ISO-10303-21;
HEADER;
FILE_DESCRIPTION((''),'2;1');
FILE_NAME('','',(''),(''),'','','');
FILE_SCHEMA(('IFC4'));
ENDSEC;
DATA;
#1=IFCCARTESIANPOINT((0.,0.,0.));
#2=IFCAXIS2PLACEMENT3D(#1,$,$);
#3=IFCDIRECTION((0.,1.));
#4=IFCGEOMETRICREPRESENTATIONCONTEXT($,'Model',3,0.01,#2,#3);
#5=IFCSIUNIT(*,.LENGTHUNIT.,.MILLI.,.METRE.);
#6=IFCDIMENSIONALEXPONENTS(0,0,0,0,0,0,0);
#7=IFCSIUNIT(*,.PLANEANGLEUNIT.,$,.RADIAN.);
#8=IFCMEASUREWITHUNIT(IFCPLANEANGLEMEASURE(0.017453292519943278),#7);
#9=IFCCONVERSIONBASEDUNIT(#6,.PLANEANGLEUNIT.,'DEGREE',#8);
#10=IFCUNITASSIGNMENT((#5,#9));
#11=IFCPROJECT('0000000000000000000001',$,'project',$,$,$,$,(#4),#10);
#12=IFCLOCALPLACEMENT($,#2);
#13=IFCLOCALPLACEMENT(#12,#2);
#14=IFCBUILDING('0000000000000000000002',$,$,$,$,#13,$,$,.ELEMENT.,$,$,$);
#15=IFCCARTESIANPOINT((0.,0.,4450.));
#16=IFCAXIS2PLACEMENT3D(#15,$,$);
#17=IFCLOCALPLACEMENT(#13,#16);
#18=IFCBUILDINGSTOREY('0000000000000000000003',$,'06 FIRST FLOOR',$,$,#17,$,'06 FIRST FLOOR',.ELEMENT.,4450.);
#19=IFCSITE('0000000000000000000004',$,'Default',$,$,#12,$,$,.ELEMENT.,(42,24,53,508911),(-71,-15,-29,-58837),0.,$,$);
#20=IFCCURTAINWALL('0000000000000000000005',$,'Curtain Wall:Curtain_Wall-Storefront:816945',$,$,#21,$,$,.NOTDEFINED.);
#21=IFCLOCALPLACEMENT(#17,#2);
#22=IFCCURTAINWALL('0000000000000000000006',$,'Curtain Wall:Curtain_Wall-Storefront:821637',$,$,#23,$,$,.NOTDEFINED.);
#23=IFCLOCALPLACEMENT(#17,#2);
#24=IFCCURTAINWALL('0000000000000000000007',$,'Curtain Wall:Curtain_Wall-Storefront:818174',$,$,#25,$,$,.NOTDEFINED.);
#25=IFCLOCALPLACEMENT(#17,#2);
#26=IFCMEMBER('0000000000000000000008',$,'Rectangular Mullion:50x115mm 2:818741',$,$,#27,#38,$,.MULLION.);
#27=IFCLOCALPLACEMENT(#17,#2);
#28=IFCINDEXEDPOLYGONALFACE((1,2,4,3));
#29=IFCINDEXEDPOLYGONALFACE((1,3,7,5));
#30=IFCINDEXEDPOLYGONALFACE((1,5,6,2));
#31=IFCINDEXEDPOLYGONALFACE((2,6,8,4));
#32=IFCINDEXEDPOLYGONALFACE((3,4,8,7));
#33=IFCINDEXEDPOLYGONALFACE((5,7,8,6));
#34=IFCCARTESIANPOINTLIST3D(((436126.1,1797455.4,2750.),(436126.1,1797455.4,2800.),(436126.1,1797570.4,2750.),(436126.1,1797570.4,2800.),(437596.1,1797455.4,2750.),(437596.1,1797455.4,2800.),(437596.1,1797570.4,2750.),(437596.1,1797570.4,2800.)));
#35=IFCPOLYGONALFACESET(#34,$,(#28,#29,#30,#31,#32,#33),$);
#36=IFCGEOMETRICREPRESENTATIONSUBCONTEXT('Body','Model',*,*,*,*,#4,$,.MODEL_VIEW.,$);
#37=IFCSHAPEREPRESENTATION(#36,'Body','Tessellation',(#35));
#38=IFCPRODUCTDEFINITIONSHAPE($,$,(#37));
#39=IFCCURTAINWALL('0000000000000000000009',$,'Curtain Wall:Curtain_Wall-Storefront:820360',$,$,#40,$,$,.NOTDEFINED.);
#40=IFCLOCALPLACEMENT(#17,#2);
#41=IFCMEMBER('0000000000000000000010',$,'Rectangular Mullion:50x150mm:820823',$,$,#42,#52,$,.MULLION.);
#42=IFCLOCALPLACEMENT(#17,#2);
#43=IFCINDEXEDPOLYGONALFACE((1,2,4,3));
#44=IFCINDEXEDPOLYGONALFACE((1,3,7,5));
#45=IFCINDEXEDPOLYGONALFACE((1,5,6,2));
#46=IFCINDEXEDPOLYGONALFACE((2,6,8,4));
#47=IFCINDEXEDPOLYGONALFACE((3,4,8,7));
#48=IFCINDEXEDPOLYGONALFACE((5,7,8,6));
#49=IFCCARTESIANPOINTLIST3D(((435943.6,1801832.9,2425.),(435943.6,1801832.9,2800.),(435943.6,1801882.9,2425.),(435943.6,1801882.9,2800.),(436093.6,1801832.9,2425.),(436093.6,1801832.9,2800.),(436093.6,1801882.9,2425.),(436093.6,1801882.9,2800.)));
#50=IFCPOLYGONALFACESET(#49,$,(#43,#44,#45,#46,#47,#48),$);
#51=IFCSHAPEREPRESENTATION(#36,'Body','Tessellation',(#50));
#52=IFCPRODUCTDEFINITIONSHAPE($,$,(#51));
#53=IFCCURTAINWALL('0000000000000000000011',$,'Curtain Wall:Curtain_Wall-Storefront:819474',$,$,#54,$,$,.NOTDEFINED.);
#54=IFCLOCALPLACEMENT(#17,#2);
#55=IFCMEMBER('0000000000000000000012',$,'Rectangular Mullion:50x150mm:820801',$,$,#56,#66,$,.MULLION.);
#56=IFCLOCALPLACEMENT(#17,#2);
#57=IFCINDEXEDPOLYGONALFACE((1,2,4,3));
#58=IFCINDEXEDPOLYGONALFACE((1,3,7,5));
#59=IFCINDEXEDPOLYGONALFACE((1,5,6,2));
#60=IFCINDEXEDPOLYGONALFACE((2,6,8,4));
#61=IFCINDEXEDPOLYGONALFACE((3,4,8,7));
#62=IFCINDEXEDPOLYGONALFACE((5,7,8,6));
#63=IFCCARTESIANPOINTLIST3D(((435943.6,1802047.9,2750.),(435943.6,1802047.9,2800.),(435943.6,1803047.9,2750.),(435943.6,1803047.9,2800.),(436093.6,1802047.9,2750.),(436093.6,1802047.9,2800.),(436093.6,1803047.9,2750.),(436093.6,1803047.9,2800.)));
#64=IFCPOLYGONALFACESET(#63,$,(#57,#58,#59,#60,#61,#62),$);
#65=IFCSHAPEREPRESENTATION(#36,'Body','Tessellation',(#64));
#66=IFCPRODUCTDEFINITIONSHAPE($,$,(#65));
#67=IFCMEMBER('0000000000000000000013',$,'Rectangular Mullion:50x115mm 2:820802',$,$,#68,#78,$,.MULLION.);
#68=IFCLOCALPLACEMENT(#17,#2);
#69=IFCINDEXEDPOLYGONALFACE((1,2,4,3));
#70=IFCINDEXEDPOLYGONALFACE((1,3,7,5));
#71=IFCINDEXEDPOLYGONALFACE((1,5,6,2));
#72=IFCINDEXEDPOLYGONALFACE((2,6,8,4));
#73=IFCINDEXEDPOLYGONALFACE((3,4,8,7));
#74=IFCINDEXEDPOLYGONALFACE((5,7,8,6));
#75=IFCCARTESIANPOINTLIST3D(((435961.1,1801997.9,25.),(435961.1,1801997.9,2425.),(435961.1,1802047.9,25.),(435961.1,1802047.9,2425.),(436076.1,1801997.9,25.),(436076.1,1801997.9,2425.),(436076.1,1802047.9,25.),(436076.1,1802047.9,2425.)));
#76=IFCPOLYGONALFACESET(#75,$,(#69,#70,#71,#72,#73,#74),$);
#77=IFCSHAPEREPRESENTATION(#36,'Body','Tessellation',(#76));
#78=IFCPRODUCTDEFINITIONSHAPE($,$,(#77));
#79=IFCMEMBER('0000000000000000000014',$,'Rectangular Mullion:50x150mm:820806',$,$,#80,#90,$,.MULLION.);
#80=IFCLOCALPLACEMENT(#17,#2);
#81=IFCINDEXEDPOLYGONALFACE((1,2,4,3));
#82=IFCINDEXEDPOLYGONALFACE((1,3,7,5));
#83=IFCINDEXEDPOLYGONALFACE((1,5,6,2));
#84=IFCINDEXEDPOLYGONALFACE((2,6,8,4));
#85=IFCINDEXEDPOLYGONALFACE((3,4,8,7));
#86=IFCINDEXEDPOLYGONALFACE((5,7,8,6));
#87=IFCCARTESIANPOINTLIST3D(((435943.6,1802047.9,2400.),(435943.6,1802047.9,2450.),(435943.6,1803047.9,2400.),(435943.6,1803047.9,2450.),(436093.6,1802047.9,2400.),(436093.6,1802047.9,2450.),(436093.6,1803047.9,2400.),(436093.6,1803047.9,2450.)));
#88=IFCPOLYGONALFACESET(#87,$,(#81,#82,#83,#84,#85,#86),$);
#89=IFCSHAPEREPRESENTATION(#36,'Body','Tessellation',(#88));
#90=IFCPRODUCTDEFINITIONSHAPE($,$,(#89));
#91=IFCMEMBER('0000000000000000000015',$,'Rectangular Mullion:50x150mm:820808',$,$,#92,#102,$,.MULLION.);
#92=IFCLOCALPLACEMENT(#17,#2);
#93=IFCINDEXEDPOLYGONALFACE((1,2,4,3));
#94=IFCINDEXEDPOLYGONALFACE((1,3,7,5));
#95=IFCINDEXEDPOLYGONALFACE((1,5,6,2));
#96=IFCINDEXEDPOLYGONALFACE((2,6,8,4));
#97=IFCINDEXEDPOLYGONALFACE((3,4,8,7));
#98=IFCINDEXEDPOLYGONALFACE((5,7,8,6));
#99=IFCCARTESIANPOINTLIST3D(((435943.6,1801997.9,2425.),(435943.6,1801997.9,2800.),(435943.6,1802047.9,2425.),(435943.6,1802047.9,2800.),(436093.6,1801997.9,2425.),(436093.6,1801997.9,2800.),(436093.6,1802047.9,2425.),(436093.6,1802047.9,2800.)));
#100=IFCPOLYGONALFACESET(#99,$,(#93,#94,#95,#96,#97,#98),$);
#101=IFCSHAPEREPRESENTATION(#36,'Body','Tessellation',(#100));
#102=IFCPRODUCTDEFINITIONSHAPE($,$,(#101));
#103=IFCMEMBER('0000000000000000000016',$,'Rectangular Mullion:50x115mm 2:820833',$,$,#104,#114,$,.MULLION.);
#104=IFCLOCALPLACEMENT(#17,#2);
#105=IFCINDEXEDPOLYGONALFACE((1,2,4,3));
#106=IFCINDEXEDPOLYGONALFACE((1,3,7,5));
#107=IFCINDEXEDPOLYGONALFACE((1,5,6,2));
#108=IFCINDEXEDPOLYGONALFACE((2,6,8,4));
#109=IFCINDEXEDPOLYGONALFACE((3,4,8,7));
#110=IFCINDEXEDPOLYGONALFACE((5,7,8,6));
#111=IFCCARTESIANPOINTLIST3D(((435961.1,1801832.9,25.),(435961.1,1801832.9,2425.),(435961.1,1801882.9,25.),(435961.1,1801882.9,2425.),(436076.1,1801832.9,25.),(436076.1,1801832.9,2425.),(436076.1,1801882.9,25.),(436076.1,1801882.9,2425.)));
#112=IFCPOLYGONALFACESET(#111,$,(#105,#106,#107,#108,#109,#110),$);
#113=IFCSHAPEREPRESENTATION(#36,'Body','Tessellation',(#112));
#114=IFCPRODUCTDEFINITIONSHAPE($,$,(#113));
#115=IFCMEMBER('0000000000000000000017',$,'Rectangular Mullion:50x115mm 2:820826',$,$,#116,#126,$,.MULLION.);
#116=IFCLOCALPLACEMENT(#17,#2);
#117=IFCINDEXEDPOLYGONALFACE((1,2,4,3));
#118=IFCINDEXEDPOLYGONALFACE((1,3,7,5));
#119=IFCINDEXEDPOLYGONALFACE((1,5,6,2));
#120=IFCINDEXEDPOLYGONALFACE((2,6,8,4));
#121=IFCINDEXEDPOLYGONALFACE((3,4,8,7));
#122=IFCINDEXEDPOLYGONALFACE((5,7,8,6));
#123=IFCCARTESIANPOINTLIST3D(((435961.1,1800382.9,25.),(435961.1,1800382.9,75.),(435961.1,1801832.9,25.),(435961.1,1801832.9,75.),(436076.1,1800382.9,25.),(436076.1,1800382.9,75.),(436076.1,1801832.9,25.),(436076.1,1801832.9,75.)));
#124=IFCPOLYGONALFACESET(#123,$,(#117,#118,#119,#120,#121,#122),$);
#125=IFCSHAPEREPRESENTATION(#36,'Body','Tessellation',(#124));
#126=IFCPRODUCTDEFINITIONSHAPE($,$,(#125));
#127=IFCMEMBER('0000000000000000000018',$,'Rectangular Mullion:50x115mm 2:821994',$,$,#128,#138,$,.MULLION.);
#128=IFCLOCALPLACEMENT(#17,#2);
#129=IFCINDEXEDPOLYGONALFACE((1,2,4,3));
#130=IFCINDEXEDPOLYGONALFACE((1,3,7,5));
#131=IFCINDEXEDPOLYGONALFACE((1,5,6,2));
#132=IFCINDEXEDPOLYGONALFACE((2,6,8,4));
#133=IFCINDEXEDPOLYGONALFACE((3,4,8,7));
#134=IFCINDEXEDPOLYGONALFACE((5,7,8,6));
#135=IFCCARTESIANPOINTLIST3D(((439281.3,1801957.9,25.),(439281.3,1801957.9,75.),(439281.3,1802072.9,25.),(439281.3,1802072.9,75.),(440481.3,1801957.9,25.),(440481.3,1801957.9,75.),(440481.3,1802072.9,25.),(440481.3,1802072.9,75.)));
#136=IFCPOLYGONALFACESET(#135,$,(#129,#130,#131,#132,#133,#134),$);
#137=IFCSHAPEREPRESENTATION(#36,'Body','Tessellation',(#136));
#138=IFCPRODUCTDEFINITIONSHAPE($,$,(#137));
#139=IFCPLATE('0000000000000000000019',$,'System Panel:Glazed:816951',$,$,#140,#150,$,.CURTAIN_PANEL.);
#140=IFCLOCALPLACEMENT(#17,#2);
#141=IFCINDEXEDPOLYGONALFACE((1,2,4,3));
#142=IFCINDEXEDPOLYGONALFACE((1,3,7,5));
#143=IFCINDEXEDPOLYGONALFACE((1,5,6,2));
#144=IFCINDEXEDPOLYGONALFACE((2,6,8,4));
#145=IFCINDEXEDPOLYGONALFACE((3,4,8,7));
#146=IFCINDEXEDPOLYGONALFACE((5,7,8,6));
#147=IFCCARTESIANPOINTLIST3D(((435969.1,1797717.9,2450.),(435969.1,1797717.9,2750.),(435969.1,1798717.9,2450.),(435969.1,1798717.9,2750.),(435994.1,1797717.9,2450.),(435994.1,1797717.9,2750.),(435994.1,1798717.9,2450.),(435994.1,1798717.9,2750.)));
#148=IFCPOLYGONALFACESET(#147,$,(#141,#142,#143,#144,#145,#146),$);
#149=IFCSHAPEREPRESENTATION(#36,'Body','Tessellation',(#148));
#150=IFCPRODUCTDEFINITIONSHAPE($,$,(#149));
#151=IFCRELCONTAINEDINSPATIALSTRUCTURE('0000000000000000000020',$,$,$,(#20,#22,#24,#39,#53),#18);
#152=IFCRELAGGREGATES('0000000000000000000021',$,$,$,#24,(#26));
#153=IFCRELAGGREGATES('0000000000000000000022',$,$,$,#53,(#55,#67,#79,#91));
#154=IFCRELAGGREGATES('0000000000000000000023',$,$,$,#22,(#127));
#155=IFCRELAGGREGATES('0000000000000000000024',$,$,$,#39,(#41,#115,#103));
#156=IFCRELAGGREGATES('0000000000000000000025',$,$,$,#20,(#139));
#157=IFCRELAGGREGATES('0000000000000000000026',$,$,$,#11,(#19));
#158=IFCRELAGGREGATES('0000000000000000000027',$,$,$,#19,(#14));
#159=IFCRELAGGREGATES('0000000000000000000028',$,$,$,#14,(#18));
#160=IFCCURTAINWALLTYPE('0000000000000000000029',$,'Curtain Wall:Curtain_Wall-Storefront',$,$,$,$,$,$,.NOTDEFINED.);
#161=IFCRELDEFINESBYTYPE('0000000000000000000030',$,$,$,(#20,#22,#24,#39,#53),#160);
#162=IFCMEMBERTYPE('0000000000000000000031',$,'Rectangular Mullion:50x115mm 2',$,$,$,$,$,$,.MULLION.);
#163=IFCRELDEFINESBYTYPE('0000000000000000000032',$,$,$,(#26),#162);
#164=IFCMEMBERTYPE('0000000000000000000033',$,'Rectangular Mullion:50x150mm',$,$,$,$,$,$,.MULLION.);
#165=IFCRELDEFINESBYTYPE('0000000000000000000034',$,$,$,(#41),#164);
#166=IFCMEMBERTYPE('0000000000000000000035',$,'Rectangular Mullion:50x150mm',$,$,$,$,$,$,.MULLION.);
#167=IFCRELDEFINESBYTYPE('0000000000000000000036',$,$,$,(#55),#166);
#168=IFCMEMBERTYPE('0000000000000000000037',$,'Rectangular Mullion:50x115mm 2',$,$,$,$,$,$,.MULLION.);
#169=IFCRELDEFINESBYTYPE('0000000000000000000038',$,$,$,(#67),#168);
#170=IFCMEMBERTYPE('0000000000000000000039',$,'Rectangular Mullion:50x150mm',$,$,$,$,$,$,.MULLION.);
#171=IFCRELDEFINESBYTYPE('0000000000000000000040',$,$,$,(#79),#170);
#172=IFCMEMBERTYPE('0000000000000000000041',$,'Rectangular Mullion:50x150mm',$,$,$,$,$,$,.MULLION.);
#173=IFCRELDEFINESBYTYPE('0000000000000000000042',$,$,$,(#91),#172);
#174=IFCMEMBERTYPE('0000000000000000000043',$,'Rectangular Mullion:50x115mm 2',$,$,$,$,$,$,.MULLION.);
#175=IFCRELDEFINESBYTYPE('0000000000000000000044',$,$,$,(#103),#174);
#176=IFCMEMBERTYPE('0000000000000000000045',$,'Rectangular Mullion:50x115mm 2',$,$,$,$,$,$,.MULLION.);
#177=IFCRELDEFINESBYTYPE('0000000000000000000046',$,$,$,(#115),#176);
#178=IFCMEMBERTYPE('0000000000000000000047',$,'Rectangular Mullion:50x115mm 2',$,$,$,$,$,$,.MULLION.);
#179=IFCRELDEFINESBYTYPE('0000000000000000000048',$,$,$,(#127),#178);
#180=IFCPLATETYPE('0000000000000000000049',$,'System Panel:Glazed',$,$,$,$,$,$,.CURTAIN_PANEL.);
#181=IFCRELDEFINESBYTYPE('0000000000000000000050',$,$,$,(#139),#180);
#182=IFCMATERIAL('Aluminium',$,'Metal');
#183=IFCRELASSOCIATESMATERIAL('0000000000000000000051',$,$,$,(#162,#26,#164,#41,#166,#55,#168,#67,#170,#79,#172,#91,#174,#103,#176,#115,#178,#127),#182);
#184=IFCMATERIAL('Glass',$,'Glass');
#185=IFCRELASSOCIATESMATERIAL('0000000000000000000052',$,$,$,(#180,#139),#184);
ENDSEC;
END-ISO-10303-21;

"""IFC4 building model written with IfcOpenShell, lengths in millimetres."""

from ifc_helpers import new_model, entity, si_unit, converted_unit, direction, frame, origin, place, context, subcontext, project, spatial, indexed_curve, outline, extrude, source, transform, mapped, material, type_object, type_shapes, element, aggregate, save


model = new_model("IFC4")

# Units and contexts
model_context = context("Model", 3, precision=0.01, world=origin(), true_north=direction((0.0, 1.0)))
body_context = subcontext(model_context, "Body", "Model", "MODEL_VIEW")
ifc_project = project(units=[si_unit("LENGTHUNIT", "METRE", prefix="MILLI"), converted_unit("PLANEANGLEUNIT", "DEGREE", entity("IfcPlaneAngleMeasure", 0.017453292519943278), si_unit("PLANEANGLEUNIT", "RADIAN"), dimensions=[0, 0, 0, 0, 0, 0, 0])], contexts=[model_context])

# Site, building, storey
site_placement = place(None, origin())
site = spatial("IfcSite", under=ifc_project, at=site_placement, Name="Default", CompositionType="ELEMENT", RefLatitude=(42, 24, 53, 508911), RefLongitude=(-71, -15, -29, -58837), RefElevation=0.0)
building_placement = place(site_placement, origin())
building = spatial("IfcBuilding", under=site, at=building_placement, CompositionType="ELEMENT")
storey_placement = place(building_placement, frame((0.0, 0.0, 4450.0)))
storey = spatial("IfcBuildingStorey", under=building, at=storey_placement, Name="06 FIRST FLOOR", LongName="06 FIRST FLOOR", CompositionType="ELEMENT", Elevation=4450.0)

# Curtain walls, member
curtain_wall_type = type_object("IfcCurtainWallType", Name="Curtain Wall:Curtain_Wall-Storefront", PredefinedType="NOTDEFINED")
curtain_wall_1_placement = place(storey_placement, frame((0.0, 0.0, -4450.0)))
curtain_wall_1 = element("IfcCurtainWall", 1, at=curtain_wall_1_placement, inside=storey, type_object=curtain_wall_type, Name="Curtain Wall:Curtain_Wall-Storefront:816945", PredefinedType="NOTDEFINED")
ifc_material_1 = material(Name="Aluminium", Category="Metal")
curtain_wall_2_placement = place(storey_placement, frame((0.0, 0.0, -4450.0)))
curtain_wall_2 = element("IfcCurtainWall", 2, at=curtain_wall_2_placement, inside=storey, type_object=curtain_wall_type, Name="Curtain Wall:Curtain_Wall-Storefront:821637", PredefinedType="NOTDEFINED")
curtain_wall_3_placement = place(storey_placement, frame((0.0, 0.0, -4450.0)))
curtain_wall_3 = element("IfcCurtainWall", 3, at=curtain_wall_3_placement, inside=storey, type_object=curtain_wall_type, Name="Curtain Wall:Curtain_Wall-Storefront:818174", PredefinedType="NOTDEFINED")
member_type_1 = type_object("IfcMemberType", Name="Rectangular Mullion:50x115mm 2", PredefinedType="MULLION", material=ifc_material_1)
shared_shape_1 = source(origin(), body_context, "Body", "SweptSolid", [
    extrude(outline(indexed_curve([(-25.0, -57.5), (25.0, -57.5), (25.0, 57.5), (-25.0, 57.5), (-25.0, -57.5)], self_intersect=False)), frame((-25.0, 0.0, -1470.0), z_axis=(0.0, 0.0, 1.0), x_axis=(-1.0, 0.0, 0.0)), (0.0, 0.0, 1.0), 1470.0),
])
type_shapes(member_type_1, [shared_shape_1])
member_1_placement = place(curtain_wall_3_placement, frame((437596.1, 1797512.9, 7250.0), z_axis=(1.0, 0.0, 0.0), x_axis=(0.0, 0.0, 1.0)))
member_1 = element("IfcMember", 4, at=member_1_placement, type_object=member_type_1, material=ifc_material_1, Name="Rectangular Mullion:50x115mm 2:818741", PredefinedType="MULLION", context=body_context, shape_type="MappedRepresentation", body=[
    mapped(shared_shape_1, transform((0.0, 0.0, 0.0), scale=1.0)),
])
aggregate(curtain_wall_3, [member_1])

# Curtain wall, member
curtain_wall_4_placement = place(storey_placement, frame((0.0, 0.0, -4450.0)))
curtain_wall_4 = element("IfcCurtainWall", 5, at=curtain_wall_4_placement, inside=storey, type_object=curtain_wall_type, Name="Curtain Wall:Curtain_Wall-Storefront:820360", PredefinedType="NOTDEFINED")
member_type_2 = type_object("IfcMemberType", Name="Rectangular Mullion:50x150mm", PredefinedType="MULLION", material=ifc_material_1)
shared_shape_2 = source(origin(), body_context, "Body", "SweptSolid", [
    extrude(outline(indexed_curve([(-25.0, -75.0), (25.0, -75.0), (25.0, 75.0), (-25.0, 75.0), (-25.0, -75.0)], self_intersect=False)), frame((-25.0, 0.0, -375.0), z_axis=(0.0, 0.0, 1.0), x_axis=(-1.0, 0.0, 0.0)), (0.0, 0.0, 1.0), 375.0),
])
type_shapes(member_type_2, [shared_shape_2])
member_2_placement = place(curtain_wall_4_placement, frame((436018.6, 1801882.9, 7250.0), z_axis=(0.0, 0.0, 1.0), x_axis=(0.0, 1.0, 0.0)))
member_2 = element("IfcMember", 6, at=member_2_placement, type_object=member_type_2, material=ifc_material_1, Name="Rectangular Mullion:50x150mm:820823", PredefinedType="MULLION", context=body_context, shape_type="MappedRepresentation", body=[
    mapped(shared_shape_2, transform((0.0, 0.0, 0.0), scale=1.0)),
])

# Curtain wall, members
curtain_wall_5_placement = place(storey_placement, frame((0.0, 0.0, -4450.0)))
curtain_wall_5 = element("IfcCurtainWall", 7, at=curtain_wall_5_placement, inside=storey, type_object=curtain_wall_type, Name="Curtain Wall:Curtain_Wall-Storefront:819474", PredefinedType="NOTDEFINED")
member_type_3 = type_object("IfcMemberType", Name="Rectangular Mullion:50x150mm", PredefinedType="MULLION", material=ifc_material_1)
shared_shape_3 = source(origin(), body_context, "Body", "SweptSolid", [
    extrude(outline(indexed_curve([(-25.0, -75.0), (25.0, -75.0), (25.0, 75.0), (-25.0, 75.0), (-25.0, -75.0)], self_intersect=False)), frame((-25.0, 0.0, -1000.0), z_axis=(0.0, 0.0, 1.0), x_axis=(-1.0, 0.0, 0.0)), (0.0, 0.0, 1.0), 1000.0),
])
type_shapes(member_type_3, [shared_shape_3])
member_3_placement = place(curtain_wall_5_placement, frame((436018.6, 1802047.9, 7250.0), z_axis=(0.0, -1.0, 0.0), x_axis=(0.0, 0.0, 1.0)))
member_3 = element("IfcMember", 8, at=member_3_placement, type_object=member_type_3, material=ifc_material_1, Name="Rectangular Mullion:50x150mm:820801", PredefinedType="MULLION", context=body_context, shape_type="MappedRepresentation", body=[
    mapped(shared_shape_3, transform((0.0, 0.0, 0.0), scale=1.0)),
])
member_type_4 = type_object("IfcMemberType", Name="Rectangular Mullion:50x115mm 2", PredefinedType="MULLION", material=ifc_material_1)
shared_shape_4 = source(origin(), body_context, "Body", "SweptSolid", [
    extrude(outline(indexed_curve([(-25.0, -57.5), (25.0, -57.5), (25.0, 57.5), (-25.0, 57.5), (-25.0, -57.5)], self_intersect=False)), frame((-25.0, 0.0, -2400.0), z_axis=(0.0, 0.0, 1.0), x_axis=(-1.0, 0.0, 0.0)), (0.0, 0.0, 1.0), 2400.0),
])
type_shapes(member_type_4, [shared_shape_4])
member_4_placement = place(curtain_wall_5_placement, frame((436018.6, 1801997.9, 4475.0), z_axis=(0.0, 0.0, -1.0), x_axis=(0.0, -1.0, 0.0)))
member_4 = element("IfcMember", 9, at=member_4_placement, type_object=member_type_4, material=ifc_material_1, Name="Rectangular Mullion:50x115mm 2:820802", PredefinedType="MULLION", context=body_context, shape_type="MappedRepresentation", body=[
    mapped(shared_shape_4, transform((0.0, 0.0, 0.0), scale=1.0)),
])
member_type_5 = type_object("IfcMemberType", Name="Rectangular Mullion:50x150mm", PredefinedType="MULLION", material=ifc_material_1)
shared_shape_5 = source(origin(), body_context, "Body", "SweptSolid", [
    extrude(outline(indexed_curve([(-25.0, -75.0), (25.0, -75.0), (25.0, 75.0), (-25.0, 75.0), (-25.0, -75.0)], self_intersect=False)), frame((0.0, 0.0, -1000.0), z_axis=(0.0, 0.0, 1.0), x_axis=(-1.0, 0.0, 0.0)), (0.0, 0.0, 1.0), 1000.0),
])
type_shapes(member_type_5, [shared_shape_5])
member_5_placement = place(curtain_wall_5_placement, frame((436018.6, 1802047.9, 6875.0), z_axis=(0.0, -1.0, 0.0), x_axis=(0.0, 0.0, 1.0)))
member_5 = element("IfcMember", 10, at=member_5_placement, type_object=member_type_5, material=ifc_material_1, Name="Rectangular Mullion:50x150mm:820806", PredefinedType="MULLION", context=body_context, shape_type="MappedRepresentation", body=[
    mapped(shared_shape_5, transform((0.0, 0.0, 0.0), scale=1.0)),
])
member_type_6 = type_object("IfcMemberType", Name="Rectangular Mullion:50x150mm", PredefinedType="MULLION", material=ifc_material_1)
shared_shape_6 = source(origin(), body_context, "Body", "SweptSolid", [
    extrude(outline(indexed_curve([(-25.0, -75.0), (25.0, -75.0), (25.0, 75.0), (-25.0, 75.0), (-25.0, -75.0)], self_intersect=False)), frame((-25.0, 0.0, -375.0), z_axis=(0.0, 0.0, 1.0), x_axis=(-1.0, 0.0, 0.0)), (0.0, 0.0, 1.0), 375.0),
])
type_shapes(member_type_6, [shared_shape_6])
member_6_placement = place(curtain_wall_5_placement, frame((436018.6, 1801997.9, 6875.0), z_axis=(0.0, 0.0, -1.0), x_axis=(0.0, -1.0, 0.0)))
member_6 = element("IfcMember", 11, at=member_6_placement, type_object=member_type_6, material=ifc_material_1, Name="Rectangular Mullion:50x150mm:820808", PredefinedType="MULLION", context=body_context, shape_type="MappedRepresentation", body=[
    mapped(shared_shape_6, transform((0.0, 0.0, 0.0), scale=1.0)),
])
aggregate(curtain_wall_5, [member_3, member_4, member_5, member_6])

# Members
member_type_7 = type_object("IfcMemberType", Name="Rectangular Mullion:50x115mm 2", PredefinedType="MULLION", material=ifc_material_1)
shared_shape_7 = source(origin(), body_context, "Body", "SweptSolid", [
    extrude(outline(indexed_curve([(-25.0, -57.5), (25.0, -57.5), (25.0, 57.5), (-25.0, 57.5), (-25.0, -57.5)], self_intersect=False)), frame((-25.0, 0.0, -2400.0), z_axis=(0.0, 0.0, 1.0), x_axis=(-1.0, 0.0, 0.0)), (0.0, 0.0, 1.0), 2400.0),
])
type_shapes(member_type_7, [shared_shape_7])
member_7_placement = place(curtain_wall_4_placement, frame((436018.6, 1801882.9, 6875.0), z_axis=(0.0, 0.0, 1.0), x_axis=(0.0, 1.0, 0.0)))
member_7 = element("IfcMember", 12, at=member_7_placement, type_object=member_type_7, material=ifc_material_1, Name="Rectangular Mullion:50x115mm 2:820833", PredefinedType="MULLION", context=body_context, shape_type="MappedRepresentation", body=[
    mapped(shared_shape_7, transform((0.0, 0.0, 0.0), scale=1.0)),
])
member_type_8 = type_object("IfcMemberType", Name="Rectangular Mullion:50x115mm 2", PredefinedType="MULLION", material=ifc_material_1)
shared_shape_8 = source(origin(), body_context, "Body", "SweptSolid", [
    extrude(outline(indexed_curve([(-25.0, -57.5), (25.0, -57.5), (25.0, 57.5), (-25.0, 57.5), (-25.0, -57.5)], self_intersect=False)), frame((-25.0, 0.0, -1450.0), z_axis=(0.0, 0.0, 1.0), x_axis=(-1.0, 0.0, 0.0)), (0.0, 0.0, 1.0), 1450.0),
])
type_shapes(member_type_8, [shared_shape_8])
member_8_placement = place(curtain_wall_4_placement, frame((436018.6, 1801832.9, 4475.0), z_axis=(0.0, 1.0, 0.0), x_axis=(0.0, 0.0, -1.0)))
member_8 = element("IfcMember", 13, at=member_8_placement, type_object=member_type_8, material=ifc_material_1, Name="Rectangular Mullion:50x115mm 2:820826", PredefinedType="MULLION", context=body_context, shape_type="MappedRepresentation", body=[
    mapped(shared_shape_8, transform((0.0, 0.0, 0.0), scale=1.0)),
])
member_type_9 = type_object("IfcMemberType", Name="Rectangular Mullion:50x115mm 2", PredefinedType="MULLION", material=ifc_material_1)
shared_shape_9 = source(origin(), body_context, "Body", "SweptSolid", [
    extrude(outline(indexed_curve([(-25.0, -57.5), (25.0, -57.5), (25.0, 57.5), (-25.0, 57.5), (-25.0, -57.5)], self_intersect=False)), frame((-25.0, 0.0, -1200.0), z_axis=(0.0, 0.0, 1.0), x_axis=(-1.0, 0.0, 0.0)), (0.0, 0.0, 1.0), 1200.0),
])
type_shapes(member_type_9, [shared_shape_9])
member_9_placement = place(curtain_wall_2_placement, frame((439281.3, 1802015.4, 4475.0), z_axis=(-1.0, 0.0, 0.0), x_axis=(0.0, 0.0, -1.0)))
member_9 = element("IfcMember", 14, at=member_9_placement, type_object=member_type_9, material=ifc_material_1, Name="Rectangular Mullion:50x115mm 2:821994", PredefinedType="MULLION", context=body_context, shape_type="MappedRepresentation", body=[
    mapped(shared_shape_9, transform((0.0, 0.0, 0.0), scale=1.0)),
])

# Plate
ifc_material_2 = material(Name="Glass", Category="Glass")
plate_type_1 = type_object("IfcPlateType", Name="System Panel:Glazed", PredefinedType="CURTAIN_PANEL", material=ifc_material_2)
shared_shape_10 = source(origin(), body_context, "Body", "SweptSolid", [
    extrude(outline(indexed_curve([(-12.5, -500.0), (12.5, -500.0), (12.5, 500.0), (-12.5, 500.0), (-12.5, -500.0)], self_intersect=False)), frame((0.0, -37.0, 0.0), z_axis=(0.0, 0.0, 1.0), x_axis=(0.0, 1.0, 0.0)), (0.0, 0.0, 1.0), 300.0),
])
type_shapes(plate_type_1, [shared_shape_10])
plate_1_placement = place(curtain_wall_1_placement, frame((436018.6, 1798217.9, 6900.0), z_axis=(0.0, 0.0, 1.0), x_axis=(0.0, -1.0, 0.0)))
plate_1 = element("IfcPlate", 15, at=plate_1_placement, type_object=plate_type_1, material=ifc_material_2, Name="System Panel:Glazed:816951", PredefinedType="CURTAIN_PANEL", context=body_context, shape_type="MappedRepresentation", body=[
    mapped(shared_shape_10, transform((0.0, 0.0, 0.0), scale=1.0)),
])
aggregate(curtain_wall_2, [member_9])
aggregate(curtain_wall_4, [member_2, member_8, member_7])

aggregate(curtain_wall_1, [plate_1])

save(model, "model.ifc")
